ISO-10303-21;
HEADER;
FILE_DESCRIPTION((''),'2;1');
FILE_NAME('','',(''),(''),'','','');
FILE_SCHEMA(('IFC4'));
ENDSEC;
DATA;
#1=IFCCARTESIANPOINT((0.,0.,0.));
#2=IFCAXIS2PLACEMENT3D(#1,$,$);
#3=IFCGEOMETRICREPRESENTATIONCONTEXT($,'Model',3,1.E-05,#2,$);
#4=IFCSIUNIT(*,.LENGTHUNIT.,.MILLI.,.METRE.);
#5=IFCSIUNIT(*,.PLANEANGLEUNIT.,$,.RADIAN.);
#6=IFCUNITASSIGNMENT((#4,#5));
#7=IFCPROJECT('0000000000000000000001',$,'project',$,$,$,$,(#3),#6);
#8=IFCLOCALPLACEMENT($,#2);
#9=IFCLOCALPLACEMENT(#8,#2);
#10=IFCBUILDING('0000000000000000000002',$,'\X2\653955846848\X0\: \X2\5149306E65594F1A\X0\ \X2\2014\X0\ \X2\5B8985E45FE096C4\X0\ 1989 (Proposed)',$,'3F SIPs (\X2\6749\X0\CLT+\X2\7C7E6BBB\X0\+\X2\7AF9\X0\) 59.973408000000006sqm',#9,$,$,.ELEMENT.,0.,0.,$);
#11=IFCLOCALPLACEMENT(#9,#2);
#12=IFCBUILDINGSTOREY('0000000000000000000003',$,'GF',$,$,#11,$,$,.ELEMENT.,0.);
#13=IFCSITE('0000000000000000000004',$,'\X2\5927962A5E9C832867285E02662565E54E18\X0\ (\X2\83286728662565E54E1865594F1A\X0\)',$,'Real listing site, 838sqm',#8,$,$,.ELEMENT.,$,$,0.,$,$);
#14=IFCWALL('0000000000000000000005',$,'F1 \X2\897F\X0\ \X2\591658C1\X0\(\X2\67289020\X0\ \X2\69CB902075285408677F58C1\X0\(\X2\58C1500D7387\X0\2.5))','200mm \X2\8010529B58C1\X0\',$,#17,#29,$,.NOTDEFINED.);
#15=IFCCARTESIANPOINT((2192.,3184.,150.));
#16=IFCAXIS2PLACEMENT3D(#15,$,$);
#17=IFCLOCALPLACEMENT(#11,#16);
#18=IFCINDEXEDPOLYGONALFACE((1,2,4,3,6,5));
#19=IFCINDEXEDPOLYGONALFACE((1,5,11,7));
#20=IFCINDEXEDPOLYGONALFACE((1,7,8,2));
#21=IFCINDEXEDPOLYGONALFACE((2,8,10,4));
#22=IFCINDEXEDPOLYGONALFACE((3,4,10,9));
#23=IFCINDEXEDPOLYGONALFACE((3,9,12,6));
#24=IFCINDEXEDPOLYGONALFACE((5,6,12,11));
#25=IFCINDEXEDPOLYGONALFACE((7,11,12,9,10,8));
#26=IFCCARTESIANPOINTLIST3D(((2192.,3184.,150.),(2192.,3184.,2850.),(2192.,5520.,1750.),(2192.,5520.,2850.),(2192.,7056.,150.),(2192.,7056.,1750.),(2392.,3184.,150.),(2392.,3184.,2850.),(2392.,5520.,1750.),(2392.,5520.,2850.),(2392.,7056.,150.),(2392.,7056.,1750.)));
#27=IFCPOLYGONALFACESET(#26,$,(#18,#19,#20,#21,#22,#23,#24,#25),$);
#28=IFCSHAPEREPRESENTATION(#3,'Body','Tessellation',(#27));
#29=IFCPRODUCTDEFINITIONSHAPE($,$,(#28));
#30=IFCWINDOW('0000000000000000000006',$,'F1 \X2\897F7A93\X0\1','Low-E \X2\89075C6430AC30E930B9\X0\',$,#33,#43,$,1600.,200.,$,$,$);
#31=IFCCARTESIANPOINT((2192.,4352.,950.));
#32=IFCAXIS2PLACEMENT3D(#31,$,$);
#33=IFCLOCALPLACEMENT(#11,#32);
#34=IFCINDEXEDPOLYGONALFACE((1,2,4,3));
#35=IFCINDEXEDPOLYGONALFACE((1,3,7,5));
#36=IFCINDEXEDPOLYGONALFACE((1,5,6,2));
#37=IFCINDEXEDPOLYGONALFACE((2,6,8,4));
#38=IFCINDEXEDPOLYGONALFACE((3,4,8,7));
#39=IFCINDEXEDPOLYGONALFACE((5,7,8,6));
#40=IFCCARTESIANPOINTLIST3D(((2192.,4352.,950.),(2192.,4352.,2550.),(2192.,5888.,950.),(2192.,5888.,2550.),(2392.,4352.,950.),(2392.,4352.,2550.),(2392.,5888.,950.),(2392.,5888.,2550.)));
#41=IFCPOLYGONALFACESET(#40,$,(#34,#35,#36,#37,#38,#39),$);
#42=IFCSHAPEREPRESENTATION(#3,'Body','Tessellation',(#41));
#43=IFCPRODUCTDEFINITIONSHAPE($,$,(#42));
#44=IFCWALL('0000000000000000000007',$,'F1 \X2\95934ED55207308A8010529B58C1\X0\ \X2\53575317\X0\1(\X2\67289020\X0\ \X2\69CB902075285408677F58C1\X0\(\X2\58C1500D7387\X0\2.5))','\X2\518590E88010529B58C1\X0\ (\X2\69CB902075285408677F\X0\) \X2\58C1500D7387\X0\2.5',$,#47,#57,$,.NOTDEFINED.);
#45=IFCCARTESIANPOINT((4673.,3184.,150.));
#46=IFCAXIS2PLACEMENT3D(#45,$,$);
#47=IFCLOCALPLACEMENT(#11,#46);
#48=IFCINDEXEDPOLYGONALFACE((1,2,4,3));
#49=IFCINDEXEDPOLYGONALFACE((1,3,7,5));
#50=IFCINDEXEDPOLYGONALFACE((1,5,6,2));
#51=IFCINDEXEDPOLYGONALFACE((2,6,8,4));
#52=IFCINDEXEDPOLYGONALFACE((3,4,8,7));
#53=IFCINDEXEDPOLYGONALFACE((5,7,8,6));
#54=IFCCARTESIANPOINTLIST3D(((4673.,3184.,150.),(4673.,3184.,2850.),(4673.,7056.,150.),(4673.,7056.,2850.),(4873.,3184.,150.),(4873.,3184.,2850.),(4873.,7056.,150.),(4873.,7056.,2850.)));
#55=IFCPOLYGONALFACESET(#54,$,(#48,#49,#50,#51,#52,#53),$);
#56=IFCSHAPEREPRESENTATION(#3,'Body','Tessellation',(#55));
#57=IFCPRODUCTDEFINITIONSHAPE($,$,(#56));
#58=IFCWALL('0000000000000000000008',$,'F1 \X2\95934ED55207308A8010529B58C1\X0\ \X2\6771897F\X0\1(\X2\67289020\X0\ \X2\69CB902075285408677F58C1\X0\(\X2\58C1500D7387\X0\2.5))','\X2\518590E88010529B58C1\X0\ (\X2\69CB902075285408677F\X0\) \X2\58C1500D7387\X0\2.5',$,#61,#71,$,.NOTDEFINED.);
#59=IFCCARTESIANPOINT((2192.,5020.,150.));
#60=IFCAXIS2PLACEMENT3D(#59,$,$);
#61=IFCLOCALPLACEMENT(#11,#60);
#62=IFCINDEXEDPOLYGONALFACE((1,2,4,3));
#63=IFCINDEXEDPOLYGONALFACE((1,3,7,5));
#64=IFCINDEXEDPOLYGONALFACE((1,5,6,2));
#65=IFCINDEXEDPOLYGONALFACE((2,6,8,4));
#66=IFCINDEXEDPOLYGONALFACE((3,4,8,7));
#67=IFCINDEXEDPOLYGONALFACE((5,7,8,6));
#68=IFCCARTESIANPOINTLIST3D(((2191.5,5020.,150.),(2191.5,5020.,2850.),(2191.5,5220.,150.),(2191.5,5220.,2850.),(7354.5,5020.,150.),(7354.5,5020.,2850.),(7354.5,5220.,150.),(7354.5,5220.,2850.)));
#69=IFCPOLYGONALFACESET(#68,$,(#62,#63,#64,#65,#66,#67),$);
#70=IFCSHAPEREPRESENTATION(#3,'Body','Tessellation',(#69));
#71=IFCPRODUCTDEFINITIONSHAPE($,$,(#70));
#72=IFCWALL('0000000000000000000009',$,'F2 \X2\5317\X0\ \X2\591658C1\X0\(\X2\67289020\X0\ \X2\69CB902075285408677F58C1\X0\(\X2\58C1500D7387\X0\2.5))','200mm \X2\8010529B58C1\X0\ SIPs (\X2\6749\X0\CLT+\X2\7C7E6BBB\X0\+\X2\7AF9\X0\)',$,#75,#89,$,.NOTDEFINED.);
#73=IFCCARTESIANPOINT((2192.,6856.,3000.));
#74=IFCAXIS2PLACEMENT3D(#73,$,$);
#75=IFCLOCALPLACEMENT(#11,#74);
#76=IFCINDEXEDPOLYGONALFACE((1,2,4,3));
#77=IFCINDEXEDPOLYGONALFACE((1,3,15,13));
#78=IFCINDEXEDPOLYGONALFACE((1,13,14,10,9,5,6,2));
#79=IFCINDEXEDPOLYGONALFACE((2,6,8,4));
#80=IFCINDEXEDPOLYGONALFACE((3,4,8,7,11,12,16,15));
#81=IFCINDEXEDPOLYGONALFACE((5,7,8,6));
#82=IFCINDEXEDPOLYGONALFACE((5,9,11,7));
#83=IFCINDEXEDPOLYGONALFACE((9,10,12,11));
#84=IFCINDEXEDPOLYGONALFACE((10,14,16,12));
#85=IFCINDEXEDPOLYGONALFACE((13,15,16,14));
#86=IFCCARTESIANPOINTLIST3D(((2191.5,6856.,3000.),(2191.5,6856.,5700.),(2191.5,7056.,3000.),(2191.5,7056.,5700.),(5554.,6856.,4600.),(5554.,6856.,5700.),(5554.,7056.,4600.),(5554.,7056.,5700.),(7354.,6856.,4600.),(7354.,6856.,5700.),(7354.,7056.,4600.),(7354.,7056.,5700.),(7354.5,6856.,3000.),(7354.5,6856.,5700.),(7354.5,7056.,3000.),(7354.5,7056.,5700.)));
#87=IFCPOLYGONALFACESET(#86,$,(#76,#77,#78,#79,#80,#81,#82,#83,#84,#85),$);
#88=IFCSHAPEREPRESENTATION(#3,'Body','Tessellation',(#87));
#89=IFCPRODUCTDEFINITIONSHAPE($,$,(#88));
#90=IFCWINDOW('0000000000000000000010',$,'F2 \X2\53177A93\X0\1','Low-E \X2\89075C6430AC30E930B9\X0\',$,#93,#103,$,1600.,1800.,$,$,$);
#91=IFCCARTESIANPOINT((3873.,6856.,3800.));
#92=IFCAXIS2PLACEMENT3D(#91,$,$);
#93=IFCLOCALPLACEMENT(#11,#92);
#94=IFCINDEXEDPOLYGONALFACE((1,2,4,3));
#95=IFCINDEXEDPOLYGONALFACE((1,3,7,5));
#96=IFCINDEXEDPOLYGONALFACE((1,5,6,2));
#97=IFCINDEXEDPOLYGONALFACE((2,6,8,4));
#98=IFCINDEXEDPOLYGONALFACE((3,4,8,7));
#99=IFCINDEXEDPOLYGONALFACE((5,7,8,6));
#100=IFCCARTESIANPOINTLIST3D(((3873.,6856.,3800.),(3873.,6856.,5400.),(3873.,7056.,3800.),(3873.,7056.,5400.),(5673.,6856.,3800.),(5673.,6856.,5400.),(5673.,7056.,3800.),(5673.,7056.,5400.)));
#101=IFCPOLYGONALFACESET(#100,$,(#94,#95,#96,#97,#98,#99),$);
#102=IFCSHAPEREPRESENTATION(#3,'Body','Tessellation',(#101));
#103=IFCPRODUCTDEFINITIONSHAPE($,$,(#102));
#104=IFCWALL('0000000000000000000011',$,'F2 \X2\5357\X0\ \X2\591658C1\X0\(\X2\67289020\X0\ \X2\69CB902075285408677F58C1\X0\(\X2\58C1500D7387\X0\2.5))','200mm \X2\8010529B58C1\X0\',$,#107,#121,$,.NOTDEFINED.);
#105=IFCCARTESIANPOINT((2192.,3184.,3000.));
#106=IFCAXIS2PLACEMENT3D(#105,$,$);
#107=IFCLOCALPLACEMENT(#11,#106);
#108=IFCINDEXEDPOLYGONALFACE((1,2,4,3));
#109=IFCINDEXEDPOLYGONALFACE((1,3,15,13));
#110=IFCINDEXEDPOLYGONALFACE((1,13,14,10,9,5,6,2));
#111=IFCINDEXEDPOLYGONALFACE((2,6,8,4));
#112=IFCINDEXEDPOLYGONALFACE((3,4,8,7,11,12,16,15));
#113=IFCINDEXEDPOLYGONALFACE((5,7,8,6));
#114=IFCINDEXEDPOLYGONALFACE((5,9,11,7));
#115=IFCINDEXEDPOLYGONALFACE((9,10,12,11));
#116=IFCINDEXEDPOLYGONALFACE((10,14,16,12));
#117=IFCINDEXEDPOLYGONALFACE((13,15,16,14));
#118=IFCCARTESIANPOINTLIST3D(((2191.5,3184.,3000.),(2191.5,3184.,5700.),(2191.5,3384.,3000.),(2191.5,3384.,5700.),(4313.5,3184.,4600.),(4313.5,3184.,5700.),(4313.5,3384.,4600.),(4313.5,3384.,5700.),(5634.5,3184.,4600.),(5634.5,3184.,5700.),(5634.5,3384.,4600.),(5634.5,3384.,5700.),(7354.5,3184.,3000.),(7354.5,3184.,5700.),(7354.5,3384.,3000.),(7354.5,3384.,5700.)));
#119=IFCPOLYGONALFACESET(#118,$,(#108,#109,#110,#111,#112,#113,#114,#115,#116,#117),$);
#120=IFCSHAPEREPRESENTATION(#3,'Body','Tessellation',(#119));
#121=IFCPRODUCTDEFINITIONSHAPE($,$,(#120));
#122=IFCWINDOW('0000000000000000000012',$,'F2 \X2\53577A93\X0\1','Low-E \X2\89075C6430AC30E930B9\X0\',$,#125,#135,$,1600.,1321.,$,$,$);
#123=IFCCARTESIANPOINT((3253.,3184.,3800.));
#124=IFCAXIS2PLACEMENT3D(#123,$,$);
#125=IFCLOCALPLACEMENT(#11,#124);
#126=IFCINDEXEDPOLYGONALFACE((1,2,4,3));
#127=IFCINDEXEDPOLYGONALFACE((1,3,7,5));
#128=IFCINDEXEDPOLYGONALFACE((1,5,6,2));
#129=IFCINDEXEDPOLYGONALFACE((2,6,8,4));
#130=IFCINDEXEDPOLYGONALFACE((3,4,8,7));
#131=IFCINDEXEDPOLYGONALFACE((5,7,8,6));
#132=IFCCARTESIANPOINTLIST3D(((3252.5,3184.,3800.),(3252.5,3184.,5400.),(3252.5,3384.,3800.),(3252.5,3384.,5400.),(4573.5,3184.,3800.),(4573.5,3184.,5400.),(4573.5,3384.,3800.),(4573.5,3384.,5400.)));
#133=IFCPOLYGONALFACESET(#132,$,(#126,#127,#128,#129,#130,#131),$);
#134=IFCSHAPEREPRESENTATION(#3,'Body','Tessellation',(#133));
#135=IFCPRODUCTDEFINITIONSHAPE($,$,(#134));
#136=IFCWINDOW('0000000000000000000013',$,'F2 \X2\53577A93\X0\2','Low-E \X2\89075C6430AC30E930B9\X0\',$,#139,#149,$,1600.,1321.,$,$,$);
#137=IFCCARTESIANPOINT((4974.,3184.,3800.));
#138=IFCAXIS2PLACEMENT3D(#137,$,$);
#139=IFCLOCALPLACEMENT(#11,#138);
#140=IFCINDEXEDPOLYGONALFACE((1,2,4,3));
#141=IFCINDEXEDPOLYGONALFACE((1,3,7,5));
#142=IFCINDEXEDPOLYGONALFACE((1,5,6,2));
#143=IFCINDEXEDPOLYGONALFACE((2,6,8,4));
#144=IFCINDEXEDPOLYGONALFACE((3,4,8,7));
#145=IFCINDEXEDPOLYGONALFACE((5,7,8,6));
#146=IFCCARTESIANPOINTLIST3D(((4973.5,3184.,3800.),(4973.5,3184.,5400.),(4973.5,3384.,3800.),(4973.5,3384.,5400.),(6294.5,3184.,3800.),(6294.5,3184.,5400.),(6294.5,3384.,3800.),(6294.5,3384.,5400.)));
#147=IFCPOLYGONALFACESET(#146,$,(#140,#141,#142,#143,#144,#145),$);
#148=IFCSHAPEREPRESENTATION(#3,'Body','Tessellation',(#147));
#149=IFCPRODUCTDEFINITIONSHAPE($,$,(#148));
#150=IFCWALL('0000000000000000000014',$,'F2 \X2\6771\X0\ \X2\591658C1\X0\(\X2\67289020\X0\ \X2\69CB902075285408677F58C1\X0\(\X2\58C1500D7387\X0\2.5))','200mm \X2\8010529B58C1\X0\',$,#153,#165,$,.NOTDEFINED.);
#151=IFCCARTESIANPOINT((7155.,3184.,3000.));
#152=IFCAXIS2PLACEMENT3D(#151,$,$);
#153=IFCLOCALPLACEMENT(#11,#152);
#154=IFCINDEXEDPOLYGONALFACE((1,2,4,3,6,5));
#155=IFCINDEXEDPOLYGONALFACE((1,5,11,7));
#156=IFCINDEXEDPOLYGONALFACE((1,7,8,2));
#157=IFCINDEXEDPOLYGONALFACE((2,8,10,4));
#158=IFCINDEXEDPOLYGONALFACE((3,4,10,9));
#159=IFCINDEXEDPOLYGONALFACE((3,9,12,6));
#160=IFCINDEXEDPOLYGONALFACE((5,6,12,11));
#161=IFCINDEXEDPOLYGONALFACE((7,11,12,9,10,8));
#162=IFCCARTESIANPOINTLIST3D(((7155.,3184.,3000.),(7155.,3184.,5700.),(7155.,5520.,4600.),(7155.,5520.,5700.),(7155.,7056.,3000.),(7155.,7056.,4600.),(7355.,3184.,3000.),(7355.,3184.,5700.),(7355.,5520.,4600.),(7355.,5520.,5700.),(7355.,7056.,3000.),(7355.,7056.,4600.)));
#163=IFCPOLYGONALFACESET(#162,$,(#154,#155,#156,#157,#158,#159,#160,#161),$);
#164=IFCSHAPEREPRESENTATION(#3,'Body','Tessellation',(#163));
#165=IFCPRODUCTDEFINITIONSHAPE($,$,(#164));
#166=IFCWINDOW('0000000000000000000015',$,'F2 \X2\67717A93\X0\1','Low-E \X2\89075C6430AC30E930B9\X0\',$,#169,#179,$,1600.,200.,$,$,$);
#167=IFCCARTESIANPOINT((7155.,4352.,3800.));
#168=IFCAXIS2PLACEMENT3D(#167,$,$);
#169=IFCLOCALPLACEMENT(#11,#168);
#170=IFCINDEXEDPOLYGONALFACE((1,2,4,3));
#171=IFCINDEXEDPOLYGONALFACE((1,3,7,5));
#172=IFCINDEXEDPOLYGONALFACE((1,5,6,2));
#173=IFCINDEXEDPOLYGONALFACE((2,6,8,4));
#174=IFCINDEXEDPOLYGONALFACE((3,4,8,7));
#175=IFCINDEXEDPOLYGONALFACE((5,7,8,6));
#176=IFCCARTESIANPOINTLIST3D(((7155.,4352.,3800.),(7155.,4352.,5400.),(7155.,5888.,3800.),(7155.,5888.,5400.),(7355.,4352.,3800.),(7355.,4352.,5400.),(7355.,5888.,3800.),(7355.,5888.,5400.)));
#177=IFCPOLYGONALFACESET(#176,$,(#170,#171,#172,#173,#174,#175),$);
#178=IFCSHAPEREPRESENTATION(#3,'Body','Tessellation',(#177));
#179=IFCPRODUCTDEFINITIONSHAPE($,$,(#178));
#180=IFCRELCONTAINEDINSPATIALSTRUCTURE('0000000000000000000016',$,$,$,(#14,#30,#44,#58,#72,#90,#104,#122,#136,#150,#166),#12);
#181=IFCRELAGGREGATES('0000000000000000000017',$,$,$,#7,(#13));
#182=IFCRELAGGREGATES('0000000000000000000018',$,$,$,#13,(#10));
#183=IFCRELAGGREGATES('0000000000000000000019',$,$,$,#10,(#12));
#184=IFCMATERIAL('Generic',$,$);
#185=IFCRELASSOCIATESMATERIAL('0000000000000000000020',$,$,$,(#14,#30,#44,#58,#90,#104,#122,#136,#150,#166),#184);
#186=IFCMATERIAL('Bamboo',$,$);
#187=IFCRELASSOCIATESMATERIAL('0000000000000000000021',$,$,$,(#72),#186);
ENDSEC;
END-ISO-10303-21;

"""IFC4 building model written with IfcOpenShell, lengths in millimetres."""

from ifc_helpers import new_model, si_unit, frame, frame_2d, origin, place, context, project, spatial, rectangle, extrude, material, element, fill, save


model = new_model("IFC4")

# Units and contexts
model_context = context("Model", 3, precision=1e-05, world=origin())
ifc_project = project(units=[si_unit("LENGTHUNIT", "METRE", prefix="MILLI"), si_unit("PLANEANGLEUNIT", "RADIAN")], contexts=[model_context])

# Site, building, storey
site_placement = place(None, origin())
site = spatial("IfcSite", under=ifc_project, at=site_placement, Name="大阪府茨木市春日丘 (茨木春日丘教会)", ObjectType="Real listing site, 838sqm", CompositionType="ELEMENT", RefElevation=0.0)
building_placement = place(site_placement, origin())
building = spatial("IfcBuilding", under=site, at=building_placement, Name="改善案: 光の教会 — 安藤忠雄 1989 (Proposed)", ObjectType="3F SIPs (杉CLT+籾殻+竹) 59.973408000000006sqm", CompositionType="ELEMENT", ElevationOfRefHeight=0.0, ElevationOfTerrain=0.0)
storey_placement = place(building_placement, origin())
storey = spatial("IfcBuildingStorey", under=building, at=storey_placement, Name="GF", CompositionType="ELEMENT", Elevation=0.0)

# Shared definitions
ifc_material_1 = material(Name="Generic")

# Shared definitions
ifc_material_2 = material(Name="Bamboo")

# Wall, opening, window
wall_1_placement = place(storey_placement, frame((2192.0, 3184.0, 150.0)))
wall_1 = element("IfcWall", 1, at=wall_1_placement, inside=storey, material=ifc_material_1, Name="F1 西 外壁(木造 構造用合板壁(壁倍率2.5))", Description="200mm 耐力壁", PredefinedType="NOTDEFINED", context=model_context, shape_type="SweptSolid", body=[
    extrude(rectangle(XDim=200.0, YDim=3872.0, at=frame_2d((100.0, 1936.0))), frame((2192.0, 3184.0, 150.0)), (0.0, 0.0, 1.0), 2700.0),
])
opening_1_placement = place(storey_placement, frame((2192.0, 4352.0, 950.0)))
opening_1 = element("IfcOpeningElement", 2, at=opening_1_placement, cuts=wall_1, PredefinedType="NOTDEFINED", context=model_context, shape_type="SweptSolid", body=[
    extrude(rectangle(XDim=200.0, YDim=1536.0, at=frame_2d((100.0, 768.0))), frame((2192.0, 4352.0, 950.0)), (0.0, 0.0, 1.0), 1600.0),
])
window_1_placement = place(storey_placement, frame((2192.0, 4352.0, 950.0)))
window_1 = element("IfcWindow", 3, at=window_1_placement, inside=storey, material=ifc_material_1, Name="F1 西窓1", Description="Low-E 複層ガラス", OverallHeight=1600.0, OverallWidth=200.0, context=model_context, shape_type="SweptSolid", body=[
    extrude(rectangle(XDim=200.0, YDim=1536.0, at=frame_2d((100.0, 768.0))), frame((2192.0, 4352.0, 950.0)), (0.0, 0.0, 1.0), 1600.0),
])
fill(opening_1, window_1)

# Walls
wall_2_placement = place(storey_placement, frame((4673.0, 3184.0, 150.0)))
element("IfcWall", 4, at=wall_2_placement, inside=storey, material=ifc_material_1, Name="F1 間仕切り耐力壁 南北1(木造 構造用合板壁(壁倍率2.5))", Description="内部耐力壁 (構造用合板) 壁倍率2.5", PredefinedType="NOTDEFINED", context=model_context, shape_type="SweptSolid", body=[
    extrude(rectangle(XDim=200.0, YDim=3872.0, at=frame_2d((100.0, 1936.0))), frame((4673.0, 3184.0, 150.0)), (0.0, 0.0, 1.0), 2700.0),
])
wall_3_placement = place(storey_placement, frame((2192.0, 5020.0, 150.0)))
element("IfcWall", 5, at=wall_3_placement, inside=storey, material=ifc_material_1, Name="F1 間仕切り耐力壁 東西1(木造 構造用合板壁(壁倍率2.5))", Description="内部耐力壁 (構造用合板) 壁倍率2.5", PredefinedType="NOTDEFINED", context=model_context, shape_type="SweptSolid", body=[
    extrude(rectangle(XDim=5163.0, YDim=200.0, at=frame_2d((2581.0, 100.0))), frame((2192.0, 5020.0, 150.0)), (0.0, 0.0, 1.0), 2700.0),
])

# Wall, opening, window
wall_4_placement = place(storey_placement, frame((2192.0, 6856.0, 3000.0)))
wall_4 = element("IfcWall", 6, at=wall_4_placement, inside=storey, material=ifc_material_2, Name="F2 北 外壁(木造 構造用合板壁(壁倍率2.5))", Description="200mm 耐力壁 SIPs (杉CLT+籾殻+竹)", PredefinedType="NOTDEFINED", context=model_context, shape_type="SweptSolid", body=[
    extrude(rectangle(XDim=5163.0, YDim=200.0, at=frame_2d((2581.0, 100.0))), frame((2192.0, 6856.0, 3000.0)), (0.0, 0.0, 1.0), 2700.0),
])
opening_2_placement = place(storey_placement, frame((3873.0, 6856.0, 3800.0)))
opening_2 = element("IfcOpeningElement", 7, at=opening_2_placement, cuts=wall_4, PredefinedType="NOTDEFINED", context=model_context, shape_type="SweptSolid", body=[
    extrude(rectangle(XDim=1800.0, YDim=200.0, at=frame_2d((900.0, 100.0))), frame((3873.0, 6856.0, 3800.0)), (0.0, 0.0, 1.0), 1600.0),
])
window_2_placement = place(storey_placement, frame((3873.0, 6856.0, 3800.0)))
window_2 = element("IfcWindow", 8, at=window_2_placement, inside=storey, material=ifc_material_1, Name="F2 北窓1", Description="Low-E 複層ガラス", OverallHeight=1600.0, OverallWidth=1800.0, context=model_context, shape_type="SweptSolid", body=[
    extrude(rectangle(XDim=1800.0, YDim=200.0, at=frame_2d((900.0, 100.0))), frame((3873.0, 6856.0, 3800.0)), (0.0, 0.0, 1.0), 1600.0),
])
fill(opening_2, window_2)

# Wall, openings, windows
wall_5_placement = place(storey_placement, frame((2192.0, 3184.0, 3000.0)))
wall_5 = element("IfcWall", 9, at=wall_5_placement, inside=storey, material=ifc_material_1, Name="F2 南 外壁(木造 構造用合板壁(壁倍率2.5))", Description="200mm 耐力壁", PredefinedType="NOTDEFINED", context=model_context, shape_type="SweptSolid", body=[
    extrude(rectangle(XDim=5163.0, YDim=200.0, at=frame_2d((2581.0, 100.0))), frame((2192.0, 3184.0, 3000.0)), (0.0, 0.0, 1.0), 2700.0),
])
opening_3_placement = place(storey_placement, frame((3253.0, 3184.0, 3800.0)))
opening_3 = element("IfcOpeningElement", 10, at=opening_3_placement, cuts=wall_5, PredefinedType="NOTDEFINED", context=model_context, shape_type="SweptSolid", body=[
    extrude(rectangle(XDim=1321.0, YDim=200.0, at=frame_2d((660.0, 100.0))), frame((3253.0, 3184.0, 3800.0)), (0.0, 0.0, 1.0), 1600.0),
])
opening_4_placement = place(storey_placement, frame((4974.0, 3184.0, 3800.0)))
opening_4 = element("IfcOpeningElement", 11, at=opening_4_placement, cuts=wall_5, PredefinedType="NOTDEFINED", context=model_context, shape_type="SweptSolid", body=[
    extrude(rectangle(XDim=1321.0, YDim=200.0, at=frame_2d((660.0, 100.0))), frame((4974.0, 3184.0, 3800.0)), (0.0, 0.0, 1.0), 1600.0),
])
window_3_placement = place(storey_placement, frame((3253.0, 3184.0, 3800.0)))
window_3 = element("IfcWindow", 12, at=window_3_placement, inside=storey, material=ifc_material_1, Name="F2 南窓1", Description="Low-E 複層ガラス", OverallHeight=1600.0, OverallWidth=1321.0, context=model_context, shape_type="SweptSolid", body=[
    extrude(rectangle(XDim=1321.0, YDim=200.0, at=frame_2d((660.0, 100.0))), frame((3253.0, 3184.0, 3800.0)), (0.0, 0.0, 1.0), 1600.0),
])
fill(opening_3, window_3)
window_4_placement = place(storey_placement, frame((4974.0, 3184.0, 3800.0)))
window_4 = element("IfcWindow", 13, at=window_4_placement, inside=storey, material=ifc_material_1, Name="F2 南窓2", Description="Low-E 複層ガラス", OverallHeight=1600.0, OverallWidth=1321.0, context=model_context, shape_type="SweptSolid", body=[
    extrude(rectangle(XDim=1321.0, YDim=200.0, at=frame_2d((660.0, 100.0))), frame((4974.0, 3184.0, 3800.0)), (0.0, 0.0, 1.0), 1600.0),
])
fill(opening_4, window_4)

# Wall, opening, window
wall_6_placement = place(storey_placement, frame((7155.0, 3184.0, 3000.0)))
wall_6 = element("IfcWall", 14, at=wall_6_placement, inside=storey, material=ifc_material_1, Name="F2 東 外壁(木造 構造用合板壁(壁倍率2.5))", Description="200mm 耐力壁", PredefinedType="NOTDEFINED", context=model_context, shape_type="SweptSolid", body=[
    extrude(rectangle(XDim=200.0, YDim=3872.0, at=frame_2d((100.0, 1936.0))), frame((7155.0, 3184.0, 3000.0)), (0.0, 0.0, 1.0), 2700.0),
])
opening_5_placement = place(storey_placement, frame((7155.0, 4352.0, 3800.0)))
opening_5 = element("IfcOpeningElement", 15, at=opening_5_placement, cuts=wall_6, PredefinedType="NOTDEFINED", context=model_context, shape_type="SweptSolid", body=[
    extrude(rectangle(XDim=200.0, YDim=1536.0, at=frame_2d((100.0, 768.0))), frame((7155.0, 4352.0, 3800.0)), (0.0, 0.0, 1.0), 1600.0),
])
window_5_placement = place(storey_placement, frame((7155.0, 4352.0, 3800.0)))
window_5 = element("IfcWindow", 16, at=window_5_placement, inside=storey, material=ifc_material_1, Name="F2 東窓1", Description="Low-E 複層ガラス", OverallHeight=1600.0, OverallWidth=200.0, context=model_context, shape_type="SweptSolid", body=[
    extrude(rectangle(XDim=200.0, YDim=1536.0, at=frame_2d((100.0, 768.0))), frame((7155.0, 4352.0, 3800.0)), (0.0, 0.0, 1.0), 1600.0),
])
fill(opening_5, window_5)

save(model, "model.ifc")
